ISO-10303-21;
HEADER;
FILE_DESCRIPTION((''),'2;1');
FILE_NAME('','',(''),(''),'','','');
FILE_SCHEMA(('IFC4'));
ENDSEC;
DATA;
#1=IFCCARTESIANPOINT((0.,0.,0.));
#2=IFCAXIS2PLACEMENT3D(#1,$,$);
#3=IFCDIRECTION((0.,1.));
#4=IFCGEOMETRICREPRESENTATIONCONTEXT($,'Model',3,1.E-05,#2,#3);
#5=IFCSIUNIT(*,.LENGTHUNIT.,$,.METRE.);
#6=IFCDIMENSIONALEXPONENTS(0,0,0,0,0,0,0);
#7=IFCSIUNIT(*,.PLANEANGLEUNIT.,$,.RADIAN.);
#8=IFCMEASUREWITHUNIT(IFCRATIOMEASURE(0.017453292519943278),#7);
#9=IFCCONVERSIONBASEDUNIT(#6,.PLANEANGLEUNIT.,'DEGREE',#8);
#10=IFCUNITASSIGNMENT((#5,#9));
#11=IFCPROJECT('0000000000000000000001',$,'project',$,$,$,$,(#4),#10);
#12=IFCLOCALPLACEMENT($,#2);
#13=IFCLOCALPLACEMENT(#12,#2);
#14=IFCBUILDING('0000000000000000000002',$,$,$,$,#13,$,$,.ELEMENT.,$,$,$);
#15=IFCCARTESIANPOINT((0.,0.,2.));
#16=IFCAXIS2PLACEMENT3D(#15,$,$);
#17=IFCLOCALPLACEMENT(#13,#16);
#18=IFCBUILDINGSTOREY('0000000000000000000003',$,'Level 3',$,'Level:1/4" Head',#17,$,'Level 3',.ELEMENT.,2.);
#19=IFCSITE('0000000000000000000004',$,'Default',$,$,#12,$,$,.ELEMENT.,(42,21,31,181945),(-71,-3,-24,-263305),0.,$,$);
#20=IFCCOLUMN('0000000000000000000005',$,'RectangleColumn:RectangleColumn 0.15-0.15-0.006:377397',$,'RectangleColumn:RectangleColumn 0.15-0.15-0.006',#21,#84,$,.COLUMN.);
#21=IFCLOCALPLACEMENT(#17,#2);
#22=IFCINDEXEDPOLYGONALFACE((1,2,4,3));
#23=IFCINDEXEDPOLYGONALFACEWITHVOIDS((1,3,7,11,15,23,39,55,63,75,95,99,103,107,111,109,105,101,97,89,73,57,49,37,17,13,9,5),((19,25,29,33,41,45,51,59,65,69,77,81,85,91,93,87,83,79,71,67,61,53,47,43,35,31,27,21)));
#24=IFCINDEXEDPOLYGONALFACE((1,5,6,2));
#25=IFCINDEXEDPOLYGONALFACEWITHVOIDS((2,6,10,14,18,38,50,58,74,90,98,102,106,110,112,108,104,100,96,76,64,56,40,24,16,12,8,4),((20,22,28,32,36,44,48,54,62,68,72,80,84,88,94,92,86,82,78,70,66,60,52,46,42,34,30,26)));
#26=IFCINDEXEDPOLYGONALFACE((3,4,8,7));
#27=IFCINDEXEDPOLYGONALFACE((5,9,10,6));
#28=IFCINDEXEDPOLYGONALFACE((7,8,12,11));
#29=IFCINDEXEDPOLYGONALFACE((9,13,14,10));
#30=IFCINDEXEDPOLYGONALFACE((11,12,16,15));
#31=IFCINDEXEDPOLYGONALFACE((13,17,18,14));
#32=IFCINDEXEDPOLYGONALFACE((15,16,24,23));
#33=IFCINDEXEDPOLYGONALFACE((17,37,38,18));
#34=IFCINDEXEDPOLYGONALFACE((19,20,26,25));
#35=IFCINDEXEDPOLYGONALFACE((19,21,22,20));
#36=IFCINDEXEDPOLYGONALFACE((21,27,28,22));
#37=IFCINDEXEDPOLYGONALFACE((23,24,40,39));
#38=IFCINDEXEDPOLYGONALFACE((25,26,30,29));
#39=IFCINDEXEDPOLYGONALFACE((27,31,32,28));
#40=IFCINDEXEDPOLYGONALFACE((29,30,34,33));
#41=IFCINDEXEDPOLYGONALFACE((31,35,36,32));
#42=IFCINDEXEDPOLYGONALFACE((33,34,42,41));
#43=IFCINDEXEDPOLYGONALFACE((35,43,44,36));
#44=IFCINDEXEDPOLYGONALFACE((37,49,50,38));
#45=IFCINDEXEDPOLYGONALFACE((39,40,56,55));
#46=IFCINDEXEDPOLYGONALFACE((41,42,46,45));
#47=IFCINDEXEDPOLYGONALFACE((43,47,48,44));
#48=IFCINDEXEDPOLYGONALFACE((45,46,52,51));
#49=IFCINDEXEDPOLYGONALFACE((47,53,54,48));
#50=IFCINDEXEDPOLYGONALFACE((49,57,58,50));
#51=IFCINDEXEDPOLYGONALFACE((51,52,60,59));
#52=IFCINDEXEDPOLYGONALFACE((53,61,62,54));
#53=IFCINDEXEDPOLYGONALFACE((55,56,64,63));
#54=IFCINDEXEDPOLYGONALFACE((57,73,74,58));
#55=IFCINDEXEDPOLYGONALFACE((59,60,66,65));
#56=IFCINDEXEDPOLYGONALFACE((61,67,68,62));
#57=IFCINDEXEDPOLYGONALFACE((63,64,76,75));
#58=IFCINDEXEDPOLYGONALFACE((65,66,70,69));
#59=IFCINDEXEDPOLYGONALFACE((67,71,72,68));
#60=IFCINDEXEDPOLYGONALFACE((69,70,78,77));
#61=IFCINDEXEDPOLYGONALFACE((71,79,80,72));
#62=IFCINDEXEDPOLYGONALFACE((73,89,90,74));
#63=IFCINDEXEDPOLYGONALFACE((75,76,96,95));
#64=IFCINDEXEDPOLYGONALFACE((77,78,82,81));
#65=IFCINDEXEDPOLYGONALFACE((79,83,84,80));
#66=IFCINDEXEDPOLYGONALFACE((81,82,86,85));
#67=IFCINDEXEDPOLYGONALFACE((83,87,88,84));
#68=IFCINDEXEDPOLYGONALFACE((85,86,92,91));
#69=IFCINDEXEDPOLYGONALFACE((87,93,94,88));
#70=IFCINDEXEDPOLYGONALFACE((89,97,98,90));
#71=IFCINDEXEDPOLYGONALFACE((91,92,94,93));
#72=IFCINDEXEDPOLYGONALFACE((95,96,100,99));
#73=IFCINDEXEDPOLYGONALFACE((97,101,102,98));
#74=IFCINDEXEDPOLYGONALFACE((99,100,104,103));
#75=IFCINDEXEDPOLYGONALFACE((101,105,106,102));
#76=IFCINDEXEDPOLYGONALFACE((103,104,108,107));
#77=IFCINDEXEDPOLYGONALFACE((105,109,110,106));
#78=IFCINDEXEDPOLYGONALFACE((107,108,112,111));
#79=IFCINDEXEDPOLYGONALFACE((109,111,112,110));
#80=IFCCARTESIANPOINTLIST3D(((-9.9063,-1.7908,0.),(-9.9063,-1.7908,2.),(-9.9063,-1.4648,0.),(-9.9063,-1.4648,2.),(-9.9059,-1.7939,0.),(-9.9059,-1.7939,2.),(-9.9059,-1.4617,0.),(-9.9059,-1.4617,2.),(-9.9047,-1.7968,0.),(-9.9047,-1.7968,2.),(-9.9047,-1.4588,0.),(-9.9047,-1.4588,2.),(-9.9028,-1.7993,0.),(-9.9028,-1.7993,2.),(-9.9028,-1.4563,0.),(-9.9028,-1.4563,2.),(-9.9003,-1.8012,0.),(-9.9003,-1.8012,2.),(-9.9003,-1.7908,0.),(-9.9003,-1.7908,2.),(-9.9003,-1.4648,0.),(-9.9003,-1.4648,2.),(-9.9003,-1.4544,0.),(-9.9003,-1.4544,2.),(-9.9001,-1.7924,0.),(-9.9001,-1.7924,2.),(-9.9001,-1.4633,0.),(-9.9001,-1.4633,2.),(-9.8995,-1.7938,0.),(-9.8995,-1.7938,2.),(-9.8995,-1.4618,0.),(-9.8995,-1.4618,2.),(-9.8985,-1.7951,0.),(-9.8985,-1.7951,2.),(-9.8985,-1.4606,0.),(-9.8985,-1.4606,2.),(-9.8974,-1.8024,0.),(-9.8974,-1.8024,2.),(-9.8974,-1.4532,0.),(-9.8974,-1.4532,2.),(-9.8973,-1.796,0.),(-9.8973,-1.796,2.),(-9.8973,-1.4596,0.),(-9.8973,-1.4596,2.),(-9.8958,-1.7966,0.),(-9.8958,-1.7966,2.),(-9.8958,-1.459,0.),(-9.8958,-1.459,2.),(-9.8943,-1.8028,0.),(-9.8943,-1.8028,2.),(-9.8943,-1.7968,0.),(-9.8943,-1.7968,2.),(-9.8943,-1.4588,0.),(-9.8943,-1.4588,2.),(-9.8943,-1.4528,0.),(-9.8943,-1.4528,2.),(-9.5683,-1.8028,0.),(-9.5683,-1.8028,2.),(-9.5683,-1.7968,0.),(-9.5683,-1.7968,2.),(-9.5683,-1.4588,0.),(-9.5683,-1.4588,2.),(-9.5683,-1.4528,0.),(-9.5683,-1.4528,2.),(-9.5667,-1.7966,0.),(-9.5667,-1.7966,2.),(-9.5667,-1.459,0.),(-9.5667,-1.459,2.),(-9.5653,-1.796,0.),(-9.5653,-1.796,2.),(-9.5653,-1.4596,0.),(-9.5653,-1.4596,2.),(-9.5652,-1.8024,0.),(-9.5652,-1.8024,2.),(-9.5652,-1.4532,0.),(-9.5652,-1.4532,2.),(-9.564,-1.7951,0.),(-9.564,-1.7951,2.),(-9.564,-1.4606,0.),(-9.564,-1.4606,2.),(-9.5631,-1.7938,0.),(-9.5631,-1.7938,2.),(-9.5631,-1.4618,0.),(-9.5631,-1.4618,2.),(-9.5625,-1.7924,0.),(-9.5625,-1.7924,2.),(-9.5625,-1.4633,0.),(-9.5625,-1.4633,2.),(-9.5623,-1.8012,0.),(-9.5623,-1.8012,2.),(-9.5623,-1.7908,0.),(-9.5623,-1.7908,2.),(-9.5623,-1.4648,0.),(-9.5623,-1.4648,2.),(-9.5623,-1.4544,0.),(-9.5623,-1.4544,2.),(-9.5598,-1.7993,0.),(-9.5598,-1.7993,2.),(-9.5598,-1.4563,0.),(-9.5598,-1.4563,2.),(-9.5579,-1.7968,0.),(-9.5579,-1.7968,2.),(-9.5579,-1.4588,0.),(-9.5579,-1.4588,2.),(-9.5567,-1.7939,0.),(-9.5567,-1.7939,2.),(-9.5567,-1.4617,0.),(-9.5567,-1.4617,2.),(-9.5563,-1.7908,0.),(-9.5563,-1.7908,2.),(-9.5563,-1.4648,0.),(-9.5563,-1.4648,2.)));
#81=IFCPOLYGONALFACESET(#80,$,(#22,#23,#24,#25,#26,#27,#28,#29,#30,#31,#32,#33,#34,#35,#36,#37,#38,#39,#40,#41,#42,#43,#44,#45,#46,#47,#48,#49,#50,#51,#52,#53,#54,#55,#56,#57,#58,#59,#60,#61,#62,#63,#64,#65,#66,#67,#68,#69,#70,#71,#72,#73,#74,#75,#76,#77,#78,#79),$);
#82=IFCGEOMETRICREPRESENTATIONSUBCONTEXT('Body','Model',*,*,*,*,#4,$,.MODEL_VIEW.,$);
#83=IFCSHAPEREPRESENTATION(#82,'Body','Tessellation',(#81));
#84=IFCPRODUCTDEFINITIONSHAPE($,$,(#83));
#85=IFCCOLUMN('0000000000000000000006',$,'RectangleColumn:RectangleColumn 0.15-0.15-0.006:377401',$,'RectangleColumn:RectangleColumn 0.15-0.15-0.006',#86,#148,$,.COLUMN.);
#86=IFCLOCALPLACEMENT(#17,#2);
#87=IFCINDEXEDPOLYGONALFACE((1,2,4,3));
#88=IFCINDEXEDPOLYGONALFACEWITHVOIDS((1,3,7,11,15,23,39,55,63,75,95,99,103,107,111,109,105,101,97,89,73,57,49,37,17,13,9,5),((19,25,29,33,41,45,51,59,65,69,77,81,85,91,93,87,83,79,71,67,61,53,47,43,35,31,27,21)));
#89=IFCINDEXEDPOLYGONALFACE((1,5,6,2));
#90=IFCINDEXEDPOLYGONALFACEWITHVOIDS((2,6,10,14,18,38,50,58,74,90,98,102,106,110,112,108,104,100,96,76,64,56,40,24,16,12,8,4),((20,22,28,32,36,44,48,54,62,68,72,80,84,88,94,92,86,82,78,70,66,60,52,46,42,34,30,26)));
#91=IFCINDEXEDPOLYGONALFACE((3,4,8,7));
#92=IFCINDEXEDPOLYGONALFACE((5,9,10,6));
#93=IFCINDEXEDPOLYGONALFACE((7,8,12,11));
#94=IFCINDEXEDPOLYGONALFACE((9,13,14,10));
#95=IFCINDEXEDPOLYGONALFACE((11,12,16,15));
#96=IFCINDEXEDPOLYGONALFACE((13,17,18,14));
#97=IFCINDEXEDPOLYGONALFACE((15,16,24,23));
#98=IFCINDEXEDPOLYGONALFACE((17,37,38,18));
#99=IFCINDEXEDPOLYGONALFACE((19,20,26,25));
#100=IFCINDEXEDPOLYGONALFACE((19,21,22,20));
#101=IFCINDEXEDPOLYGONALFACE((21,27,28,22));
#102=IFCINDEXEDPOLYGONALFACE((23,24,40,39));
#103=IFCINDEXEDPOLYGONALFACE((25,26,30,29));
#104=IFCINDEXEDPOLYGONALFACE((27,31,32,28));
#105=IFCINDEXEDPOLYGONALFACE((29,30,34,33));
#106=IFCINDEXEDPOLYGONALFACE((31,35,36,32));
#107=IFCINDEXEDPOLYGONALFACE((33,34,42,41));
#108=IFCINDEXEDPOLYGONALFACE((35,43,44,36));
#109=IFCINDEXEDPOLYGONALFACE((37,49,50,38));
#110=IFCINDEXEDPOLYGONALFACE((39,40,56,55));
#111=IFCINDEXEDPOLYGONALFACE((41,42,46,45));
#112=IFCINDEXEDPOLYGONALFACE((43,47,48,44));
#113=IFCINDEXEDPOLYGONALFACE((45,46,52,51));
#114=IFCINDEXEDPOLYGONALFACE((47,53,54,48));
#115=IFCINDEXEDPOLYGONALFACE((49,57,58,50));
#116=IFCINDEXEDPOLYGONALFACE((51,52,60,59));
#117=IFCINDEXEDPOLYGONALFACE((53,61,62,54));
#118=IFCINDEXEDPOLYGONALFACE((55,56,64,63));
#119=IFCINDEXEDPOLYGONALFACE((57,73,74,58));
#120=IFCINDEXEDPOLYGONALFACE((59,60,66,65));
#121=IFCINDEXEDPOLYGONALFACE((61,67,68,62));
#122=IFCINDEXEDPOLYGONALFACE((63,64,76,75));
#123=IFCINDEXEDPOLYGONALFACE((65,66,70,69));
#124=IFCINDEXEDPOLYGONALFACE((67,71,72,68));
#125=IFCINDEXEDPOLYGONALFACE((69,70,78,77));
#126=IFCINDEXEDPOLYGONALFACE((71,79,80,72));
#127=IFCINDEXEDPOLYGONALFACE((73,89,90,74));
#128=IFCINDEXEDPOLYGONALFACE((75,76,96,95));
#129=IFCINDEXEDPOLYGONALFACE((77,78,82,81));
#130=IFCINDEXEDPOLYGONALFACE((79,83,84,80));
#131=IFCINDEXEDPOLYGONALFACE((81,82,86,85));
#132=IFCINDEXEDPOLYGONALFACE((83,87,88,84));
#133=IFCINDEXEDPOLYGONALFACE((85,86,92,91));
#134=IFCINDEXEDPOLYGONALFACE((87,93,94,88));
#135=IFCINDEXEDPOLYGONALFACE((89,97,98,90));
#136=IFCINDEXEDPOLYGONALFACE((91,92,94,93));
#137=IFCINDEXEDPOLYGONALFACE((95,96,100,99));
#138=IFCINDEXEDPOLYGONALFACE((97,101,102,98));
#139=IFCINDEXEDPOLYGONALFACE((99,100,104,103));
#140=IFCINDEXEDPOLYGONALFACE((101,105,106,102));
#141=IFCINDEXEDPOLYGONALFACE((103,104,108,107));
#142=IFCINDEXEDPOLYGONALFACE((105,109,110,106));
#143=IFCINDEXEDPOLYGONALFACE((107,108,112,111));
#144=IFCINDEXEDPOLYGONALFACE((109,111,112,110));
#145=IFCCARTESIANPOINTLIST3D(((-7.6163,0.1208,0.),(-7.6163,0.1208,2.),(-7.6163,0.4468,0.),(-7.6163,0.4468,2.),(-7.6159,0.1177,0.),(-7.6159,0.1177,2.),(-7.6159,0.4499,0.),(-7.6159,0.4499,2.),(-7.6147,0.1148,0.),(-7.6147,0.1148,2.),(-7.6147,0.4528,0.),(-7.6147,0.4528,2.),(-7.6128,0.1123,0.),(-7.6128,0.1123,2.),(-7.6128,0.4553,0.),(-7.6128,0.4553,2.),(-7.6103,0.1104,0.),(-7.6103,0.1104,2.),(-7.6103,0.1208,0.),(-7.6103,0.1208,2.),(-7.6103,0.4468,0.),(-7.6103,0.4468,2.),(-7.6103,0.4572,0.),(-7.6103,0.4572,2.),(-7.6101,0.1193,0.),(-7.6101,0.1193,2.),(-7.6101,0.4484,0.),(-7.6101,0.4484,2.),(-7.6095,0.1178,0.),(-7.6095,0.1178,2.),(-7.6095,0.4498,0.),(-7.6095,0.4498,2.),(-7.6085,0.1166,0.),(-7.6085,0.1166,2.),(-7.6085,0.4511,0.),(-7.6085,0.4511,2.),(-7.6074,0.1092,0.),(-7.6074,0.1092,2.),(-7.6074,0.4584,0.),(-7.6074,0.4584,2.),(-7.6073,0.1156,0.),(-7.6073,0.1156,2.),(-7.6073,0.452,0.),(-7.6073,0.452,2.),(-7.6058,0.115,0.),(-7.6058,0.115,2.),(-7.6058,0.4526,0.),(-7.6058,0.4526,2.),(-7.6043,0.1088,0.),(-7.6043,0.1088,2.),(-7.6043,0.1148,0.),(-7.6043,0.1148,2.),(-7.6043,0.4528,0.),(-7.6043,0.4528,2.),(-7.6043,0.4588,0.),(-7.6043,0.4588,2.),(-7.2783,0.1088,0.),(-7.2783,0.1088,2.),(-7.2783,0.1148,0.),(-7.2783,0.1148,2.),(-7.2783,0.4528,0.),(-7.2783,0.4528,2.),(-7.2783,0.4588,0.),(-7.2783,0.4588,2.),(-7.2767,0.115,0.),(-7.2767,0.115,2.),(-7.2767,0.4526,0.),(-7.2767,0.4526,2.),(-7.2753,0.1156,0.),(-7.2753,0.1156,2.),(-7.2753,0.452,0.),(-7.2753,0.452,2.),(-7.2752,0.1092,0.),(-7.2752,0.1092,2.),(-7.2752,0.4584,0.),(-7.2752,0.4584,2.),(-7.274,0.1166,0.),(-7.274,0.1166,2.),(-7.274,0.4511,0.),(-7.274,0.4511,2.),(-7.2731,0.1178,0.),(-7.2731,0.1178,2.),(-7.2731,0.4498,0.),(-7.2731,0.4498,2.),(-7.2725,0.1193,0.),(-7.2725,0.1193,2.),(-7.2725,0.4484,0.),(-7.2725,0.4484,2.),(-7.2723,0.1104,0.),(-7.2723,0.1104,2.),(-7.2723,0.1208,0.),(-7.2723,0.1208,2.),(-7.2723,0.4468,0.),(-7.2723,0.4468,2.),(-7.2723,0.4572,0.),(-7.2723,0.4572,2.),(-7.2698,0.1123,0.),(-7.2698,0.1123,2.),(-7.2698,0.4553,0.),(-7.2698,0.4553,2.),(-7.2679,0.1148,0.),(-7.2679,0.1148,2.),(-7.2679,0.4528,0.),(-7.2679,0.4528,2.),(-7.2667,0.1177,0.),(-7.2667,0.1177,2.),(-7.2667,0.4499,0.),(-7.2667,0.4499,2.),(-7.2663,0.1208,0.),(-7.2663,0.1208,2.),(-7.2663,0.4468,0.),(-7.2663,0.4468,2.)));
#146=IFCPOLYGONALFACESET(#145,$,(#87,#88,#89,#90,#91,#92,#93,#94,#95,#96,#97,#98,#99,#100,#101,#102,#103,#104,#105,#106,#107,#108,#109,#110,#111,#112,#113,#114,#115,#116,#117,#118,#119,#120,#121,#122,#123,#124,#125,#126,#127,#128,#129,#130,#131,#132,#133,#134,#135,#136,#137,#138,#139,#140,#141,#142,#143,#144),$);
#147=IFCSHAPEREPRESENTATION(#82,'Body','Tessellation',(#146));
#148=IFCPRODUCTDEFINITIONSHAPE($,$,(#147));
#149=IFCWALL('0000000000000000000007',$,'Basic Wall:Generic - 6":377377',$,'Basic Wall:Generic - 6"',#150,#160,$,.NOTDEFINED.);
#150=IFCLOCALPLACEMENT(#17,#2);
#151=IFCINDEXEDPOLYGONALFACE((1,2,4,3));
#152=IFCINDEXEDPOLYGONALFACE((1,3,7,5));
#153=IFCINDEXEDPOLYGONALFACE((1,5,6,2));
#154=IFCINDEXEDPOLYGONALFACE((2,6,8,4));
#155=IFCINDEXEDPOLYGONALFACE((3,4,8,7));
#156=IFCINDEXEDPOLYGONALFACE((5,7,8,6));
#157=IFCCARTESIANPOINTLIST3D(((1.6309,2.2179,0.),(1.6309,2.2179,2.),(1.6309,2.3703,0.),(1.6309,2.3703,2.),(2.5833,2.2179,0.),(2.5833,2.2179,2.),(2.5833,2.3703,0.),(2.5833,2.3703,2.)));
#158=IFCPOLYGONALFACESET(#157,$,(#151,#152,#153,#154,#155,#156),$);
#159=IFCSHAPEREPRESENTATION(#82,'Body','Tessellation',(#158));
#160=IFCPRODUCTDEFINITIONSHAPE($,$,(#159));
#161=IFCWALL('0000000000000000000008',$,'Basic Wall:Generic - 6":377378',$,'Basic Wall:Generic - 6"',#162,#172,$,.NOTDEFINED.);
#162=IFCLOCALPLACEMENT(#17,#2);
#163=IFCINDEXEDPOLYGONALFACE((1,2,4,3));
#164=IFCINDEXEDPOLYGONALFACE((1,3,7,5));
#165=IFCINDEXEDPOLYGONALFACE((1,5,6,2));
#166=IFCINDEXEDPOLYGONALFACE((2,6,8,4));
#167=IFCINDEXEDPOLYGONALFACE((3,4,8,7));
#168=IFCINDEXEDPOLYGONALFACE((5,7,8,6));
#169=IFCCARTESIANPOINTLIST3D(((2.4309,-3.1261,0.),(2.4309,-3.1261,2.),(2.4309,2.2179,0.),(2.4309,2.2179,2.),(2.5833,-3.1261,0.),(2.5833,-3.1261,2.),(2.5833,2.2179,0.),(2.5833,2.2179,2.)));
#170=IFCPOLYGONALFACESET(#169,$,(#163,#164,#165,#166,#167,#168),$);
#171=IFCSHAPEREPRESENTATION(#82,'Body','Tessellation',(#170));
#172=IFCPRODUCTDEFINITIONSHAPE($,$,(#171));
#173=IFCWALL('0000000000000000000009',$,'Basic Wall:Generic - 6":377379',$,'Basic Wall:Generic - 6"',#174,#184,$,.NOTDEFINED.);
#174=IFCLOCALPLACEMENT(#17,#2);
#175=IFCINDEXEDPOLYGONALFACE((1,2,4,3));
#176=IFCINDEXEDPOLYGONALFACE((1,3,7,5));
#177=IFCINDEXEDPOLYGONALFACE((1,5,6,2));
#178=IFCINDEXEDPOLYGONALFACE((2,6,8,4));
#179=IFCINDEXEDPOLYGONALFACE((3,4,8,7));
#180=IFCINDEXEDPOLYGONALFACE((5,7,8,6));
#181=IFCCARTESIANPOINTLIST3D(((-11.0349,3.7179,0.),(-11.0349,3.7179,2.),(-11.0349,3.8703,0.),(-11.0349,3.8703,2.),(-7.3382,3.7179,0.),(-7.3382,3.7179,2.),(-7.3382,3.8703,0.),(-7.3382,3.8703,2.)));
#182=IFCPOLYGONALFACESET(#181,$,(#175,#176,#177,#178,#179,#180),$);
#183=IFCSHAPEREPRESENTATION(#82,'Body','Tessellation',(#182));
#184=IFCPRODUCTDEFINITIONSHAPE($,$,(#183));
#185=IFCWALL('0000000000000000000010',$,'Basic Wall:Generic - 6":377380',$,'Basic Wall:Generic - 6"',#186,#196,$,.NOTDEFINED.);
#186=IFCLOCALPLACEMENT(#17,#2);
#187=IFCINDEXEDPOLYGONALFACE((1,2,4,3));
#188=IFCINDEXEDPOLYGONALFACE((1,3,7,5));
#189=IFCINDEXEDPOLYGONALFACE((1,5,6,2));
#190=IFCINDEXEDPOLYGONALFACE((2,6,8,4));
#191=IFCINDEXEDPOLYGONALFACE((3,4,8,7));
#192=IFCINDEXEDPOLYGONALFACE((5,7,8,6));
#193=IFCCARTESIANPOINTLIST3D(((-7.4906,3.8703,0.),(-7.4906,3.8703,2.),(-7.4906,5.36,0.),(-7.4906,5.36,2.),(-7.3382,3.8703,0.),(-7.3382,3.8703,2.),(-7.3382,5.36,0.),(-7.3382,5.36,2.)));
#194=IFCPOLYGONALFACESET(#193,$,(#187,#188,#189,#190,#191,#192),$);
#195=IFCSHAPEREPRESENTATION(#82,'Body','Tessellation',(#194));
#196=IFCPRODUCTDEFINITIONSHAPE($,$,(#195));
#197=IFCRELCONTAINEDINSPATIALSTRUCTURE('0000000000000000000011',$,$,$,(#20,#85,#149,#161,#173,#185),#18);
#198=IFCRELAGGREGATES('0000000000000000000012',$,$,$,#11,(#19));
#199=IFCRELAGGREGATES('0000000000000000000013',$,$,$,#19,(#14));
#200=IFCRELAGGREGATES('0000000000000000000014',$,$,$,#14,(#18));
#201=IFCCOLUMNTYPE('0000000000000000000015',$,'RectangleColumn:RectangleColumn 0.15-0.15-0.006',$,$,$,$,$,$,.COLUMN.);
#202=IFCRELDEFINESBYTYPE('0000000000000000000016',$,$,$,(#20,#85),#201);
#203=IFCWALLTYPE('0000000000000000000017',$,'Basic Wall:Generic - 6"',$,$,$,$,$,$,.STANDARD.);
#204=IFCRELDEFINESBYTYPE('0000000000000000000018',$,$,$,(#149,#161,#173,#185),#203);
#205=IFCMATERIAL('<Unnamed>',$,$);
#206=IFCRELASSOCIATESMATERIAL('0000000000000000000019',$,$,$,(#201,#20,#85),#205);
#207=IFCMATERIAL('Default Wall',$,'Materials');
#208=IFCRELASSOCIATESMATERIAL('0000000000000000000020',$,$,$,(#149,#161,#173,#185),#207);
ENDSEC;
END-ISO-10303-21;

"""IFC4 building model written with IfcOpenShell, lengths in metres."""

from ifc_helpers import new_model, entity, si_unit, converted_unit, direction, frame, origin, place, context, subcontext, project, spatial, line, arc, indexed_curve, outline, extrude, source, transform, mapped, material, type_object, type_shapes, element, save


model = new_model("IFC4")

# Units and contexts
model_context = context("Model", 3, precision=1e-05, world=origin(), true_north=direction((0.0, 1.0)))
body_context = subcontext(model_context, "Body", "Model", "MODEL_VIEW")
ifc_project = project(units=[si_unit("LENGTHUNIT", "METRE"), converted_unit("PLANEANGLEUNIT", "DEGREE", entity("IfcRatioMeasure", 0.017453292519943278), si_unit("PLANEANGLEUNIT", "RADIAN"), dimensions=[0, 0, 0, 0, 0, 0, 0])], contexts=[model_context])

# Site, building, storey
site_placement = place(None, origin())
site = spatial("IfcSite", under=ifc_project, at=site_placement, Name="Default", CompositionType="ELEMENT", RefLatitude=(42, 21, 31, 181945), RefLongitude=(-71, -3, -24, -263305), RefElevation=0.0)
building_placement = place(site_placement, origin())
building = spatial("IfcBuilding", under=site, at=building_placement, CompositionType="ELEMENT")
storey_placement = place(building_placement, frame((0.0, 0.0, 2.0)))
storey = spatial("IfcBuildingStorey", under=building, at=storey_placement, Name="Level 3", ObjectType="Level:1/4\" Head", LongName="Level 3", CompositionType="ELEMENT", Elevation=2.0)

# Columns
ifc_material_1 = material(Name="<Unnamed>")
column_type = type_object("IfcColumnType", Name="RectangleColumn:RectangleColumn 0.15-0.15-0.006", PredefinedType="COLUMN", material=ifc_material_1)
shared_shape = source(origin(), body_context, "Body", "SweptSolid", [
    extrude(outline(indexed_curve([(-0.163, -0.175), (0.163, -0.175), (0.1715, -0.1715), (0.175, -0.163), (0.175, 0.163), (0.1715, 0.1715), (0.163, 0.175), (-0.163, 0.175), (-0.1715, 0.1715), (-0.175, 0.163), (-0.175, -0.163), (-0.1715, -0.1715)], segments=[line(1, 2), arc(2, 3, 4), line(4, 5), arc(5, 6, 7), line(7, 8), arc(8, 9, 10), line(10, 11), arc(11, 12, 1)], self_intersect=False), holes=[indexed_curve([(-0.163, -0.169), (-0.1672, -0.1672), (-0.169, -0.163), (-0.169, 0.163), (-0.1672, 0.1672), (-0.163, 0.169), (0.163, 0.169), (0.1672, 0.1672), (0.169, 0.163), (0.169, -0.163), (0.1672, -0.1672), (0.163, -0.169)], segments=[arc(1, 2, 3), line(3, 4), arc(4, 5, 6), line(6, 7), arc(7, 8, 9), line(9, 10), arc(10, 11, 12), line(12, 1)], self_intersect=False)]), frame((0.0, 0.0, 2.0), z_axis=(0.0, 0.0, 1.0), x_axis=(-1.0, 0.0, 0.0)), (0.0, 0.0, 1.0), 2.0),
])
type_shapes(column_type, [shared_shape])
for number, where, name in (
    (1, (-9.7313, -1.6278, -2.0), "RectangleColumn:RectangleColumn 0.15-0.15-0.006:377397"),
    (2, (-7.4413, 0.2838, -2.0), "RectangleColumn:RectangleColumn 0.15-0.15-0.006:377401"),
):
    element("IfcColumn", number, at=place(storey_placement, frame(where)), inside=storey, type_object=column_type, material=ifc_material_1, Name=name, ObjectType="RectangleColumn:RectangleColumn 0.15-0.15-0.006", PredefinedType="COLUMN", context=body_context, shape_type="MappedRepresentation", body=[
        mapped(shared_shape, transform((0.0, 0.0, 0.0), scale=1.0)),
    ])

# Walls
ifc_material_2 = material(Name="Default Wall", Category="Materials")
wall_type_1 = type_object("IfcWallType", Name="Basic Wall:Generic - 6\"", PredefinedType="STANDARD")
wall_1_placement = place(storey_placement, frame((2.5833, 2.2941, 0.0), z_axis=(0.0, 0.0, 1.0), x_axis=(-1.0, 0.0, 0.0)))
element("IfcWall", 3, at=wall_1_placement, inside=storey, type_object=wall_type_1, material=ifc_material_2, Name="Basic Wall:Generic - 6\":377377", ObjectType="Basic Wall:Generic - 6\"", PredefinedType="NOTDEFINED", context=body_context, shape_type="SweptSolid", body=[
    extrude(outline(indexed_curve([(0.9524, 0.0762), (0.0, 0.0762), (0.0, -0.0762), (0.9524, -0.0762), (0.9524, 0.0762)], self_intersect=False)), origin(), (0.0, 0.0, 1.0), 2.0),
])
wall_2_placement = place(storey_placement, frame((2.5071, -3.1261, 0.0), z_axis=(0.0, 0.0, 1.0), x_axis=(0.0, 1.0, 0.0)))
element("IfcWall", 4, at=wall_2_placement, inside=storey, type_object=wall_type_1, material=ifc_material_2, Name="Basic Wall:Generic - 6\":377378", ObjectType="Basic Wall:Generic - 6\"", PredefinedType="NOTDEFINED", context=body_context, shape_type="SweptSolid", body=[
    extrude(outline(indexed_curve([(5.344, 0.0762), (0.0, 0.0762), (0.0, -0.0762), (5.344, -0.0762), (5.344, 0.0762)], self_intersect=False)), origin(), (0.0, 0.0, 1.0), 2.0),
])
wall_3_placement = place(storey_placement, frame((-7.3382, 3.7941, 0.0), z_axis=(0.0, 0.0, 1.0), x_axis=(-1.0, 0.0, 0.0)))
element("IfcWall", 5, at=wall_3_placement, inside=storey, type_object=wall_type_1, material=ifc_material_2, Name="Basic Wall:Generic - 6\":377379", ObjectType="Basic Wall:Generic - 6\"", PredefinedType="NOTDEFINED", context=body_context, shape_type="SweptSolid", body=[
    extrude(outline(indexed_curve([(3.6968, 0.0762), (0.0, 0.0762), (0.0, -0.0762), (3.6968, -0.0762), (3.6968, 0.0762)], self_intersect=False)), origin(), (0.0, 0.0, 1.0), 2.0),
])
wall_4_placement = place(storey_placement, frame((-7.4144, 5.36, 0.0), z_axis=(0.0, 0.0, 1.0), x_axis=(0.0, -1.0, 0.0)))
element("IfcWall", 6, at=wall_4_placement, inside=storey, type_object=wall_type_1, material=ifc_material_2, Name="Basic Wall:Generic - 6\":377380", ObjectType="Basic Wall:Generic - 6\"", PredefinedType="NOTDEFINED", context=body_context, shape_type="SweptSolid", body=[
    extrude(outline(indexed_curve([(1.4897, 0.0762), (0.0, 0.0762), (0.0, -0.0762), (1.4897, -0.0762), (1.4897, 0.0762)], self_intersect=False)), origin(), (0.0, 0.0, 1.0), 2.0),
])

save(model, "model.ifc")
